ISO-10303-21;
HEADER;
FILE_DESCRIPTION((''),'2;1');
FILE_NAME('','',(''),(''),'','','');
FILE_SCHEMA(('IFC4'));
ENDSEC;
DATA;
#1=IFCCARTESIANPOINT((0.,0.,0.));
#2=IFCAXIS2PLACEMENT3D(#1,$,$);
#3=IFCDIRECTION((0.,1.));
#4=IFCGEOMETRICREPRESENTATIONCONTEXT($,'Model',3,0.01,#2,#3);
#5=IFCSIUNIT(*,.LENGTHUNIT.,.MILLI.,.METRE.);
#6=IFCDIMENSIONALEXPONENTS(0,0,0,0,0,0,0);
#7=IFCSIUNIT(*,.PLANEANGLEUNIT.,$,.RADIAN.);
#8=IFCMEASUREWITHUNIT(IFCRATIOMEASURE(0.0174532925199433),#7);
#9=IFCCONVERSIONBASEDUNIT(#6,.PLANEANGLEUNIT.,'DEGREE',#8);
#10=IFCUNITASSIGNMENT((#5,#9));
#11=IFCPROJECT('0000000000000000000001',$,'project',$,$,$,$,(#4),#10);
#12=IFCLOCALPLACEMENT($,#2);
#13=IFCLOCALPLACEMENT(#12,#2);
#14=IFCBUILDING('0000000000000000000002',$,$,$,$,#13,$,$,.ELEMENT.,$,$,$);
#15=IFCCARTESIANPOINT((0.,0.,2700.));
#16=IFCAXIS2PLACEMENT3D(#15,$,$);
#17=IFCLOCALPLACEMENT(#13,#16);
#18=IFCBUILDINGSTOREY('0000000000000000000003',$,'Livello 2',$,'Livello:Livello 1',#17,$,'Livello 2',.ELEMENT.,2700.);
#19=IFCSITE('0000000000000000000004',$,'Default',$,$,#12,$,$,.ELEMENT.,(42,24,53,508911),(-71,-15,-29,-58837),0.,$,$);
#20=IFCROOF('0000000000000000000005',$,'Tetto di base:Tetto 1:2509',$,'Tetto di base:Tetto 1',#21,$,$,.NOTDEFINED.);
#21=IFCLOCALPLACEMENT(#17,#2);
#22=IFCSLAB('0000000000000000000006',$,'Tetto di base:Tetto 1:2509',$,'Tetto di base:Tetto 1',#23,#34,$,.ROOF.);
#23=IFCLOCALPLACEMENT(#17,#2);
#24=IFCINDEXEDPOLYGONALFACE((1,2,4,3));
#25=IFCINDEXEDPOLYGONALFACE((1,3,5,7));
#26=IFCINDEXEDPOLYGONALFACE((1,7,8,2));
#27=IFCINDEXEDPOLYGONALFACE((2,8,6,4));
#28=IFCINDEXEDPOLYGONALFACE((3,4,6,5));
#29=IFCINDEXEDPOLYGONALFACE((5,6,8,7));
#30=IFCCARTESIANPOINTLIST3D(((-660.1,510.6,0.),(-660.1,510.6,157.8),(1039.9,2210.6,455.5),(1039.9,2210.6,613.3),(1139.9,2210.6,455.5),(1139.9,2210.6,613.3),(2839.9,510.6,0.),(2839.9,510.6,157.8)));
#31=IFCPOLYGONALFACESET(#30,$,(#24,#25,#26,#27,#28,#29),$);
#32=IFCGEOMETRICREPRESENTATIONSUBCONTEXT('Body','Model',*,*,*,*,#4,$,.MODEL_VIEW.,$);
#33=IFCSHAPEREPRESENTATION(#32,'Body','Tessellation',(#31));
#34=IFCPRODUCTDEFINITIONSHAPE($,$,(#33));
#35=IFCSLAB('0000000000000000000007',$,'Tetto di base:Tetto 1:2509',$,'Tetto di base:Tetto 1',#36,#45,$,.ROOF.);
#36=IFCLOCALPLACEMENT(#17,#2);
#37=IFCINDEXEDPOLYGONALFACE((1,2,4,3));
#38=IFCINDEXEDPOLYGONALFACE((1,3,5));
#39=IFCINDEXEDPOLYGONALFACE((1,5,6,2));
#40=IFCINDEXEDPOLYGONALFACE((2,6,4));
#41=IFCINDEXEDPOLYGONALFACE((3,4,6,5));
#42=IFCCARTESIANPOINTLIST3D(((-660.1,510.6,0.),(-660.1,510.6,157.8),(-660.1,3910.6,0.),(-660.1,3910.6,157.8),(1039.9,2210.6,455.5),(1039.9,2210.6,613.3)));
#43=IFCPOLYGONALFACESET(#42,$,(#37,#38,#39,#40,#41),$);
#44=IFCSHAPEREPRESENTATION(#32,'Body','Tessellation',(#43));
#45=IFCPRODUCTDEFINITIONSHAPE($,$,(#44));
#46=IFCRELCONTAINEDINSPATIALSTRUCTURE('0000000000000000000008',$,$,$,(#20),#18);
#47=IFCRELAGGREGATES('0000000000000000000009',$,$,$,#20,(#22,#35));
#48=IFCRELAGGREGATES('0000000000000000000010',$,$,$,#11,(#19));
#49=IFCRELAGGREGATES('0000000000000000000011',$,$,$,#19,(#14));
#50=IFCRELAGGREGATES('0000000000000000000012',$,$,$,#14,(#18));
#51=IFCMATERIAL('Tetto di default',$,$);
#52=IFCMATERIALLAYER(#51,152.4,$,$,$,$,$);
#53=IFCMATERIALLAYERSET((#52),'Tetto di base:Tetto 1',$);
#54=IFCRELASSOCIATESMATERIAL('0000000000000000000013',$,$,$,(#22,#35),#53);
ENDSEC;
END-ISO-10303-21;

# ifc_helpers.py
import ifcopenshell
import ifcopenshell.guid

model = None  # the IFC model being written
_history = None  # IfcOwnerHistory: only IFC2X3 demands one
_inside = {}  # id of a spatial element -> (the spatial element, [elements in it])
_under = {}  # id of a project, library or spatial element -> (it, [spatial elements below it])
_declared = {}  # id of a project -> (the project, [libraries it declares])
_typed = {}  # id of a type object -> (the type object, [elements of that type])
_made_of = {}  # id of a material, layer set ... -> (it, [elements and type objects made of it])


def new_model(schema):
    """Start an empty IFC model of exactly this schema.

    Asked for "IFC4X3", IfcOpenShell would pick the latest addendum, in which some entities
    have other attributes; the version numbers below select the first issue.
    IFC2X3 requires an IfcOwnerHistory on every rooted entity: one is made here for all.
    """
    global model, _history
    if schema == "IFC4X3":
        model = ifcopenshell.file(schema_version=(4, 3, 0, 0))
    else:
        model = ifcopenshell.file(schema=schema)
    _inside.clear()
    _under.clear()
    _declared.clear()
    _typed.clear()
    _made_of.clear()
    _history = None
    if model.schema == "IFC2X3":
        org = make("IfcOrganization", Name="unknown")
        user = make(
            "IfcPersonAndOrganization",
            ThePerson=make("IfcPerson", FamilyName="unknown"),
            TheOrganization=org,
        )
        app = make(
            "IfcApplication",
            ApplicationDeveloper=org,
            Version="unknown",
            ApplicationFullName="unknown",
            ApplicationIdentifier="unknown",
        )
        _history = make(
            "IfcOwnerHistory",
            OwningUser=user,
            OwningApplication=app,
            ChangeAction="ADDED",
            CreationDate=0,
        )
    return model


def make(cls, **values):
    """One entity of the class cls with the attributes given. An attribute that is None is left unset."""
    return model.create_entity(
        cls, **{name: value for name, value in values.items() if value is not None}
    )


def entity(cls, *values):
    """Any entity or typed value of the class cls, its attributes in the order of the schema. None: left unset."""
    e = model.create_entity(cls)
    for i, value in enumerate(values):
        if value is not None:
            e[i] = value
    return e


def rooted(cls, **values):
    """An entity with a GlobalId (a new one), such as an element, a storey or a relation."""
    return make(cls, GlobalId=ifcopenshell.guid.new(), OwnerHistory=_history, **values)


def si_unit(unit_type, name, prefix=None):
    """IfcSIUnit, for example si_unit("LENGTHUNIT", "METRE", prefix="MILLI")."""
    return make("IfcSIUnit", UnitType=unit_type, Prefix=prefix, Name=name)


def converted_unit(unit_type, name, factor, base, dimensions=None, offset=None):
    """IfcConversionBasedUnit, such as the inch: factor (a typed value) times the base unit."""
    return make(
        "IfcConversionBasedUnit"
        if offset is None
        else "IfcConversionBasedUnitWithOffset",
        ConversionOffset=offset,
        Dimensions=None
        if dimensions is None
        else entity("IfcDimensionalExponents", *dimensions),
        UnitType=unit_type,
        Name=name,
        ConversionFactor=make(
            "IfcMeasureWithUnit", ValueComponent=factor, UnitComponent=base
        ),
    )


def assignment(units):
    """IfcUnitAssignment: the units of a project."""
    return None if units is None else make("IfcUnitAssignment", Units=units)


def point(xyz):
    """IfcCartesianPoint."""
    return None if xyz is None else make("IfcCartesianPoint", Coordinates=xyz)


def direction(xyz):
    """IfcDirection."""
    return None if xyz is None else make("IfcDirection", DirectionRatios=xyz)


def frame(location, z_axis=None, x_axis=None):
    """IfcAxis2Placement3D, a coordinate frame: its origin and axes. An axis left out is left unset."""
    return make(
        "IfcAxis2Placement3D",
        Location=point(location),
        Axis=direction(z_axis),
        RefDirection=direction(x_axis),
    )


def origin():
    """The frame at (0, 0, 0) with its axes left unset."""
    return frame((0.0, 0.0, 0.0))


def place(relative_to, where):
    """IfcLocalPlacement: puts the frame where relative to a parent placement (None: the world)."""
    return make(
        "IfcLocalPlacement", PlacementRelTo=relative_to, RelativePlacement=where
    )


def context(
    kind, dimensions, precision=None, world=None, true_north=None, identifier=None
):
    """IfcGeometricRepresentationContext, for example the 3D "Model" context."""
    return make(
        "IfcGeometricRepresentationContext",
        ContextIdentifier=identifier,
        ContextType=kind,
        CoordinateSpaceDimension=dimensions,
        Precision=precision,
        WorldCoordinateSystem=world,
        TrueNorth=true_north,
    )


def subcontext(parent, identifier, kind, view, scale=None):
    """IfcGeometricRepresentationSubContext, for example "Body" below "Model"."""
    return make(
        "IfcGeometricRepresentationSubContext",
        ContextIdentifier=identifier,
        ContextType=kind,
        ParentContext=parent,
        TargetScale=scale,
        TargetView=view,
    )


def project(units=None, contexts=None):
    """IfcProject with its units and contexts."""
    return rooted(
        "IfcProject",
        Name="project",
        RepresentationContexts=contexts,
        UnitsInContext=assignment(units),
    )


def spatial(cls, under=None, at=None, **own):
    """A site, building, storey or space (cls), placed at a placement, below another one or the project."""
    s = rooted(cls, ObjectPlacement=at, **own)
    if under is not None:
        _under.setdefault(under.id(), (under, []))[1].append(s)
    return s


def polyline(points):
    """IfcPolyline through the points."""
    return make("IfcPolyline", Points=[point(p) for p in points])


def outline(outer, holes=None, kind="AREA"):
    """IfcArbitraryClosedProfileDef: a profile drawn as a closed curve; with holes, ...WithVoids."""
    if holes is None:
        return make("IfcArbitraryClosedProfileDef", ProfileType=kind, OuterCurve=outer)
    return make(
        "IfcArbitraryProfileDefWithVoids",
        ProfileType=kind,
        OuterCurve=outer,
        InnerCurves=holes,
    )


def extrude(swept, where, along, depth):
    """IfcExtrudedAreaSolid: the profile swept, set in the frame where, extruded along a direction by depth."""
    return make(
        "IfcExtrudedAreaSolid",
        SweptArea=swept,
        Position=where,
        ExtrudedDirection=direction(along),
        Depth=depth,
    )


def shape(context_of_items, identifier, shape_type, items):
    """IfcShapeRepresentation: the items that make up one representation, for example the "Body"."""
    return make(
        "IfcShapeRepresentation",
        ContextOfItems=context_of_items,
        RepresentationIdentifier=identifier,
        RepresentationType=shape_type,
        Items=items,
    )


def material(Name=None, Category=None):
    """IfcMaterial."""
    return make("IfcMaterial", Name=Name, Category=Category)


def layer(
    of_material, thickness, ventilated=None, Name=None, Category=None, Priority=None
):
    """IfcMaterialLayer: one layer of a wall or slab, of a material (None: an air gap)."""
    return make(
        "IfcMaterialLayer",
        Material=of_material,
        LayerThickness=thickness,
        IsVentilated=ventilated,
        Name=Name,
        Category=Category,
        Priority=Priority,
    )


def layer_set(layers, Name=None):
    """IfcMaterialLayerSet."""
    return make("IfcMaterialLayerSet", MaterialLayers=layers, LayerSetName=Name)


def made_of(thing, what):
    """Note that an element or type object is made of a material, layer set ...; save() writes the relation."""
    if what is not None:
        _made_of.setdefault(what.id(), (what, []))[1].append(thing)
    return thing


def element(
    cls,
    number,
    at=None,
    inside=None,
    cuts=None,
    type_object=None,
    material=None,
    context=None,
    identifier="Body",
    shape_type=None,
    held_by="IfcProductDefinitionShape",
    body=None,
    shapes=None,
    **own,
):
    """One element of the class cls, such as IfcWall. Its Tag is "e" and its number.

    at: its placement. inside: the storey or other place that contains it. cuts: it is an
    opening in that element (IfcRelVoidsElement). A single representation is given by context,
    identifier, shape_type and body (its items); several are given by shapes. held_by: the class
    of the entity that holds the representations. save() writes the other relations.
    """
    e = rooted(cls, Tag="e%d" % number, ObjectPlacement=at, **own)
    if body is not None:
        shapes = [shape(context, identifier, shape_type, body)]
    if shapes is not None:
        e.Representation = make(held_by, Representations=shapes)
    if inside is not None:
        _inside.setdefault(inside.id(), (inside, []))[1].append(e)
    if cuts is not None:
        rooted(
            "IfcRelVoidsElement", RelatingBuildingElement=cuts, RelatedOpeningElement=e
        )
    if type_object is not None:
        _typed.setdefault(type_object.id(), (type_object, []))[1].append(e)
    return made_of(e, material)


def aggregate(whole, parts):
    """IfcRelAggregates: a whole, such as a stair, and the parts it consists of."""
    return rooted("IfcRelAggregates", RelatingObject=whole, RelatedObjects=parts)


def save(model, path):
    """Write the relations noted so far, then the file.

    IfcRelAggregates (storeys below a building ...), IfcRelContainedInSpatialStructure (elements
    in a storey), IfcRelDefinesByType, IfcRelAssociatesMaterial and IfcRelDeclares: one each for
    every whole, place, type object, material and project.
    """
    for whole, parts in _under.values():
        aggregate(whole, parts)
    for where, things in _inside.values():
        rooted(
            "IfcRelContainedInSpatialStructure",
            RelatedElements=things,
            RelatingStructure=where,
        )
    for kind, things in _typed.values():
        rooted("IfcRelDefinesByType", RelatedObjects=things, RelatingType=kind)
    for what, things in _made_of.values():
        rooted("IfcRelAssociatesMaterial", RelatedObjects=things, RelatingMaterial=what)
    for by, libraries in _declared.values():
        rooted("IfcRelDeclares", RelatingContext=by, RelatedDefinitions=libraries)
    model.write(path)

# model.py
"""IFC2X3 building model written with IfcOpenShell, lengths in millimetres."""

from ifc_helpers import new_model, entity, si_unit, converted_unit, direction, frame, origin, place, context, subcontext, project, spatial, polyline, outline, extrude, material, layer, layer_set, element, aggregate, save


model = new_model("IFC2X3")

# Units and contexts
model_context = context("Model", 3, precision=0.01, world=origin(), true_north=direction((0.0, 1.0)))
body_context = subcontext(model_context, "Body", "Model", "MODEL_VIEW")
ifc_project = project(units=[si_unit("LENGTHUNIT", "METRE", prefix="MILLI"), converted_unit("PLANEANGLEUNIT", "DEGREE", entity("IfcRatioMeasure", 0.0174532925199433), si_unit("PLANEANGLEUNIT", "RADIAN"), dimensions=[0, 0, 0, 0, 0, 0, 0])], contexts=[model_context])

# Site, building, storey
site_placement = place(None, origin())
site = spatial("IfcSite", under=ifc_project, at=site_placement, Name="Default", CompositionType="ELEMENT", RefLatitude=(42, 24, 53, 508911), RefLongitude=(-71, -15, -29, -58837), RefElevation=0.0)
building_placement = place(site_placement, origin())
building = spatial("IfcBuilding", under=site, at=building_placement, CompositionType="ELEMENT")
storey_placement = place(building_placement, frame((0.0, 0.0, 2700.0)))
storey = spatial("IfcBuildingStorey", under=building, at=storey_placement, Name="Livello 2", ObjectType="Livello:Livello 1", LongName="Livello 2", CompositionType="ELEMENT", Elevation=2700.0)

# Roof, slabs
roof_placement = place(storey_placement, frame((-660.1, 510.6, 0.0)))
roof = element("IfcRoof", 1, at=roof_placement, inside=storey, Name="Tetto di base:Tetto 1:2509", ObjectType="Tetto di base:Tetto 1", ShapeType="NOTDEFINED")
ifc_material = material(Name="Tetto di default")
ifc_layer = layer(ifc_material, 152.4)
ifc_layer_set = layer_set([ifc_layer], Name="Tetto di base:Tetto 1")
slab_1_placement = place(roof_placement, origin())
slab_1 = element("IfcSlab", 2, at=slab_1_placement, material=ifc_layer_set, Name="Tetto di base:Tetto 1:2509", ObjectType="Tetto di base:Tetto 1", PredefinedType="ROOF", context=body_context, shape_type="SweptSolid", body=[
    extrude(outline(polyline([(-1750.0, -880.0), (1750.0, -880.0), (50.0, 880.0), (-50.0, 880.0), (-1750.0, -880.0)])), frame((1750.0, 850.0, 227.8), z_axis=(0.0, -0.258819, 0.965926), x_axis=(1.0, 0.0, 0.0)), (0.0, 0.258819, 0.965926), 157.8),
])
slab_2_placement = place(roof_placement, origin())
slab_2 = element("IfcSlab", 3, at=slab_2_placement, material=ifc_layer_set, Name="Tetto di base:Tetto 1:2509", ObjectType="Tetto di base:Tetto 1", PredefinedType="ROOF", context=body_context, shape_type="SweptSolid", body=[
    extrude(outline(polyline([(-880.0, 1700.0), (-880.0, -1700.0), (880.0, 0.0), (-880.0, 1700.0)])), frame((850.0, 1700.0, 227.8), z_axis=(-0.258819, 0.0, 0.965926), x_axis=(0.965926, 0.0, 0.258819)), (0.258819, 0.0, 0.965926), 157.8),
])
aggregate(roof, [slab_1, slab_2])

save(model, "model.ifc")
